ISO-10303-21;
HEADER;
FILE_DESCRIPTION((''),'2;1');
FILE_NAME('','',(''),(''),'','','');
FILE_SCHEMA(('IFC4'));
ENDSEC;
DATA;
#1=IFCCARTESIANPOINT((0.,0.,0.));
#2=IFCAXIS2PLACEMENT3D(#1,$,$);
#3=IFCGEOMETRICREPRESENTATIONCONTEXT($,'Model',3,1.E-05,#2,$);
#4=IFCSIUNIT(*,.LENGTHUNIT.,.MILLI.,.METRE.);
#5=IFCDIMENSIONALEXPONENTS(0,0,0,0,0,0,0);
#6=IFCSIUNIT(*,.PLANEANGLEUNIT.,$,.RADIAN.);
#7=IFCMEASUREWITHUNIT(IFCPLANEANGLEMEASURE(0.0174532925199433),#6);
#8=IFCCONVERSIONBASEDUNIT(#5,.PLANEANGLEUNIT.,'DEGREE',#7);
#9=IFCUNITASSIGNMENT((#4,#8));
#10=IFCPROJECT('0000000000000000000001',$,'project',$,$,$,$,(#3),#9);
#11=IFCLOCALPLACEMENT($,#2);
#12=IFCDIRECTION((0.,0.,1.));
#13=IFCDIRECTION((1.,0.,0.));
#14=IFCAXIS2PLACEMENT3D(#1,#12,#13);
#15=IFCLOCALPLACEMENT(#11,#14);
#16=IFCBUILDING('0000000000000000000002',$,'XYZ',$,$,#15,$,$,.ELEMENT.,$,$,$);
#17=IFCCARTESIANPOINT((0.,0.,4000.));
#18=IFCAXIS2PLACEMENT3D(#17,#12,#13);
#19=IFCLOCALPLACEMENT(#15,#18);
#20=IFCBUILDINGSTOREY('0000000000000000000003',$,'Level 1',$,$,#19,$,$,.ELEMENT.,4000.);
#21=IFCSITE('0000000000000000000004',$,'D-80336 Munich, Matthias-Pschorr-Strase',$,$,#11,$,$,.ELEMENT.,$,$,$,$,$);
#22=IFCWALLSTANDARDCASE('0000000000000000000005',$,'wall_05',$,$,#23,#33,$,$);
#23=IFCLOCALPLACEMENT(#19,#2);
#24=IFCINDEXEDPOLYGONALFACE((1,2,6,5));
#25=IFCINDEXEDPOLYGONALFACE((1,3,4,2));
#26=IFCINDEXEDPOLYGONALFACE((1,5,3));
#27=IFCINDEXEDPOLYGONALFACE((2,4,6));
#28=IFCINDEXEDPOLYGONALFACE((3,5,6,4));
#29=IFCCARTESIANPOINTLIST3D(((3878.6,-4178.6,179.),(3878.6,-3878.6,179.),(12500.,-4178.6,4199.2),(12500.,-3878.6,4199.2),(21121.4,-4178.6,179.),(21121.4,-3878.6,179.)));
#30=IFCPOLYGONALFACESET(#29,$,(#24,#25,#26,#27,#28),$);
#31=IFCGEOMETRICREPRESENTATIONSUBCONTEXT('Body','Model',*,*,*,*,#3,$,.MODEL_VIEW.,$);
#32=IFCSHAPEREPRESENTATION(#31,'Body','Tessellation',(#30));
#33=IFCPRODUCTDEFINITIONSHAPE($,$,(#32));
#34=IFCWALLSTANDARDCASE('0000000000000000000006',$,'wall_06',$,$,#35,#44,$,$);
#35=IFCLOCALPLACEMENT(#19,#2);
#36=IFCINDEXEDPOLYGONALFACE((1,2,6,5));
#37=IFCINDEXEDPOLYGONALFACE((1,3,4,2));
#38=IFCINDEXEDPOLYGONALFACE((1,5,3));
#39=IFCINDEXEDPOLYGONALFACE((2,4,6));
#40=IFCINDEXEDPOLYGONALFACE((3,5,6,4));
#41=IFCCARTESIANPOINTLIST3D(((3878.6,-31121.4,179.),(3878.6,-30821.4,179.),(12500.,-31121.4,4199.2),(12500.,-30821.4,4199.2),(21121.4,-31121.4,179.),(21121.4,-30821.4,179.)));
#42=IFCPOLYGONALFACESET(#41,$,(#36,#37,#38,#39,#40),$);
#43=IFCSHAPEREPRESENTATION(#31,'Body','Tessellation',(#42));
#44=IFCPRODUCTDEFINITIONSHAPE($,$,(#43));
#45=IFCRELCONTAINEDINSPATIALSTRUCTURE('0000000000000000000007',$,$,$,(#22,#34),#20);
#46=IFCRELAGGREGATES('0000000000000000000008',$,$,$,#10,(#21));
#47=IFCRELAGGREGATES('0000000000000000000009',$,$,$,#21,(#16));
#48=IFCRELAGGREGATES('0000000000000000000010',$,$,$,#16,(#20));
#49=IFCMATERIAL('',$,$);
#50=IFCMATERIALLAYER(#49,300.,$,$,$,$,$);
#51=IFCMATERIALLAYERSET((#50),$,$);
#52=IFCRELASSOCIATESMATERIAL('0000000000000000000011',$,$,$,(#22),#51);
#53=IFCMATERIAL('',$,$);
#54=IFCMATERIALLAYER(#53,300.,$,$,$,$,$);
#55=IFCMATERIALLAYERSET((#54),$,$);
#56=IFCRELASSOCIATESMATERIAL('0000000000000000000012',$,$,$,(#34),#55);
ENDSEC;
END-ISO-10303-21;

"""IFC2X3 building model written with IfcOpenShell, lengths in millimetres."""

from ifc_helpers import new_model, entity, si_unit, converted_unit, frame, origin, origin_with_axes, place, context, subcontext, project, spatial, polyline, outline, extrude, clip, bounded_halfspace, material, layer, layer_set, layer_usage, element, save


model = new_model("IFC2X3")

# Units and contexts
model_context = context("Model", 3, precision=1e-05, world=origin())
body_context = subcontext(model_context, "Body", "Model", "MODEL_VIEW")
ifc_project = project(units=[si_unit("LENGTHUNIT", "METRE", prefix="MILLI"), converted_unit("PLANEANGLEUNIT", "DEGREE", entity("IfcPlaneAngleMeasure", 0.0174532925199433), si_unit("PLANEANGLEUNIT", "RADIAN"), dimensions=[0, 0, 0, 0, 0, 0, 0])], contexts=[model_context])

# Site, building, storey
site_placement = place(None, origin())
site = spatial("IfcSite", under=ifc_project, at=site_placement, Name="D-80336 Munich, Matthias-Pschorr-Strase", CompositionType="ELEMENT")
building_placement = place(site_placement, origin_with_axes())
building = spatial("IfcBuilding", under=site, at=building_placement, Name="XYZ", CompositionType="ELEMENT")
storey_placement = place(building_placement, frame((0.0, 0.0, 4000.0), z_axis=(0.0, 0.0, 1.0), x_axis=(1.0, 0.0, 0.0)))
storey = spatial("IfcBuildingStorey", under=building, at=storey_placement, Name="Level 1", CompositionType="ELEMENT", Elevation=4000.0)

# Walls
ifc_material_1 = material(Name="")
ifc_layer_1 = layer(ifc_material_1, 300.0)
ifc_layer_set_1 = layer_set([ifc_layer_1])
ifc_layer_usage_1 = layer_usage(ifc_layer_set_1, "AXIS2", "POSITIVE", 0.0)
wall_1_placement = place(storey_placement, frame((21121.4, -3878.6, 179.0), z_axis=(0.0, 0.0, 1.0), x_axis=(-1.0, 0.0, 0.0)))
element("IfcWallStandardCase", 1, at=wall_1_placement, inside=storey, material=ifc_layer_usage_1, Name="wall_05", context=body_context, shape_type="Clipping", body=[
    clip(clip(extrude(outline(polyline([(0.0, 0.0), (17242.9, 0.0), (17242.9, 300.0), (0.0, 300.0), (0.0, 0.0)])), origin_with_axes(), (0.0, 0.0, 1.0), 4020.2), bounded_halfspace(frame((8621.4, 300.0, 4020.2), z_axis=(0.422618, 0.0, -0.906308), x_axis=(-0.906308, 0.0, -0.422618)), True, origin(), polyline([(8621.4, 300.0), (0.0, 300.0), (0.0, 0.0), (8621.4, 0.0), (8621.4, 300.0)]))), bounded_halfspace(frame((8621.4, 300.0, 4020.2), z_axis=(-0.422618, 0.0, -0.906308), x_axis=(0.0, -1.0, 0.0)), True, origin(), polyline([(8621.4, 300.0), (8621.4, 0.0), (17242.9, 0.0), (17242.9, 300.0), (8621.4, 300.0)]))),
])
ifc_material_2 = material(Name="")
ifc_layer_2 = layer(ifc_material_2, 300.0)
ifc_layer_set_2 = layer_set([ifc_layer_2])
ifc_layer_usage_2 = layer_usage(ifc_layer_set_2, "AXIS2", "POSITIVE", 0.0)
wall_2_placement = place(storey_placement, frame((3878.6, -31121.4, 179.0), z_axis=(0.0, 0.0, 1.0), x_axis=(1.0, 0.0, 0.0)))
element("IfcWallStandardCase", 2, at=wall_2_placement, inside=storey, material=ifc_layer_usage_2, Name="wall_06", context=body_context, shape_type="Clipping", body=[
    clip(clip(extrude(outline(polyline([(0.0, 0.0), (17242.9, 0.0), (17242.9, 300.0), (0.0, 300.0), (0.0, 0.0)])), origin_with_axes(), (0.0, 0.0, 1.0), 4020.2), bounded_halfspace(frame((8621.4, 0.0, 4020.2), z_axis=(-0.422618, 0.0, -0.906308), x_axis=(0.906308, 0.0, -0.422618)), True, origin(), polyline([(8621.4, 0.0), (17242.9, 0.0), (17242.9, 300.0), (8621.4, 300.0), (8621.4, 0.0)]))), bounded_halfspace(frame((0.0, 300.0, 0.0), z_axis=(0.422618, 0.0, -0.906308), x_axis=(0.0, -1.0, 0.0)), True, origin(), polyline([(0.0, 300.0), (0.0, 0.0), (8621.4, 0.0), (8621.4, 300.0), (0.0, 300.0)]))),
])

save(model, "model.ifc")
